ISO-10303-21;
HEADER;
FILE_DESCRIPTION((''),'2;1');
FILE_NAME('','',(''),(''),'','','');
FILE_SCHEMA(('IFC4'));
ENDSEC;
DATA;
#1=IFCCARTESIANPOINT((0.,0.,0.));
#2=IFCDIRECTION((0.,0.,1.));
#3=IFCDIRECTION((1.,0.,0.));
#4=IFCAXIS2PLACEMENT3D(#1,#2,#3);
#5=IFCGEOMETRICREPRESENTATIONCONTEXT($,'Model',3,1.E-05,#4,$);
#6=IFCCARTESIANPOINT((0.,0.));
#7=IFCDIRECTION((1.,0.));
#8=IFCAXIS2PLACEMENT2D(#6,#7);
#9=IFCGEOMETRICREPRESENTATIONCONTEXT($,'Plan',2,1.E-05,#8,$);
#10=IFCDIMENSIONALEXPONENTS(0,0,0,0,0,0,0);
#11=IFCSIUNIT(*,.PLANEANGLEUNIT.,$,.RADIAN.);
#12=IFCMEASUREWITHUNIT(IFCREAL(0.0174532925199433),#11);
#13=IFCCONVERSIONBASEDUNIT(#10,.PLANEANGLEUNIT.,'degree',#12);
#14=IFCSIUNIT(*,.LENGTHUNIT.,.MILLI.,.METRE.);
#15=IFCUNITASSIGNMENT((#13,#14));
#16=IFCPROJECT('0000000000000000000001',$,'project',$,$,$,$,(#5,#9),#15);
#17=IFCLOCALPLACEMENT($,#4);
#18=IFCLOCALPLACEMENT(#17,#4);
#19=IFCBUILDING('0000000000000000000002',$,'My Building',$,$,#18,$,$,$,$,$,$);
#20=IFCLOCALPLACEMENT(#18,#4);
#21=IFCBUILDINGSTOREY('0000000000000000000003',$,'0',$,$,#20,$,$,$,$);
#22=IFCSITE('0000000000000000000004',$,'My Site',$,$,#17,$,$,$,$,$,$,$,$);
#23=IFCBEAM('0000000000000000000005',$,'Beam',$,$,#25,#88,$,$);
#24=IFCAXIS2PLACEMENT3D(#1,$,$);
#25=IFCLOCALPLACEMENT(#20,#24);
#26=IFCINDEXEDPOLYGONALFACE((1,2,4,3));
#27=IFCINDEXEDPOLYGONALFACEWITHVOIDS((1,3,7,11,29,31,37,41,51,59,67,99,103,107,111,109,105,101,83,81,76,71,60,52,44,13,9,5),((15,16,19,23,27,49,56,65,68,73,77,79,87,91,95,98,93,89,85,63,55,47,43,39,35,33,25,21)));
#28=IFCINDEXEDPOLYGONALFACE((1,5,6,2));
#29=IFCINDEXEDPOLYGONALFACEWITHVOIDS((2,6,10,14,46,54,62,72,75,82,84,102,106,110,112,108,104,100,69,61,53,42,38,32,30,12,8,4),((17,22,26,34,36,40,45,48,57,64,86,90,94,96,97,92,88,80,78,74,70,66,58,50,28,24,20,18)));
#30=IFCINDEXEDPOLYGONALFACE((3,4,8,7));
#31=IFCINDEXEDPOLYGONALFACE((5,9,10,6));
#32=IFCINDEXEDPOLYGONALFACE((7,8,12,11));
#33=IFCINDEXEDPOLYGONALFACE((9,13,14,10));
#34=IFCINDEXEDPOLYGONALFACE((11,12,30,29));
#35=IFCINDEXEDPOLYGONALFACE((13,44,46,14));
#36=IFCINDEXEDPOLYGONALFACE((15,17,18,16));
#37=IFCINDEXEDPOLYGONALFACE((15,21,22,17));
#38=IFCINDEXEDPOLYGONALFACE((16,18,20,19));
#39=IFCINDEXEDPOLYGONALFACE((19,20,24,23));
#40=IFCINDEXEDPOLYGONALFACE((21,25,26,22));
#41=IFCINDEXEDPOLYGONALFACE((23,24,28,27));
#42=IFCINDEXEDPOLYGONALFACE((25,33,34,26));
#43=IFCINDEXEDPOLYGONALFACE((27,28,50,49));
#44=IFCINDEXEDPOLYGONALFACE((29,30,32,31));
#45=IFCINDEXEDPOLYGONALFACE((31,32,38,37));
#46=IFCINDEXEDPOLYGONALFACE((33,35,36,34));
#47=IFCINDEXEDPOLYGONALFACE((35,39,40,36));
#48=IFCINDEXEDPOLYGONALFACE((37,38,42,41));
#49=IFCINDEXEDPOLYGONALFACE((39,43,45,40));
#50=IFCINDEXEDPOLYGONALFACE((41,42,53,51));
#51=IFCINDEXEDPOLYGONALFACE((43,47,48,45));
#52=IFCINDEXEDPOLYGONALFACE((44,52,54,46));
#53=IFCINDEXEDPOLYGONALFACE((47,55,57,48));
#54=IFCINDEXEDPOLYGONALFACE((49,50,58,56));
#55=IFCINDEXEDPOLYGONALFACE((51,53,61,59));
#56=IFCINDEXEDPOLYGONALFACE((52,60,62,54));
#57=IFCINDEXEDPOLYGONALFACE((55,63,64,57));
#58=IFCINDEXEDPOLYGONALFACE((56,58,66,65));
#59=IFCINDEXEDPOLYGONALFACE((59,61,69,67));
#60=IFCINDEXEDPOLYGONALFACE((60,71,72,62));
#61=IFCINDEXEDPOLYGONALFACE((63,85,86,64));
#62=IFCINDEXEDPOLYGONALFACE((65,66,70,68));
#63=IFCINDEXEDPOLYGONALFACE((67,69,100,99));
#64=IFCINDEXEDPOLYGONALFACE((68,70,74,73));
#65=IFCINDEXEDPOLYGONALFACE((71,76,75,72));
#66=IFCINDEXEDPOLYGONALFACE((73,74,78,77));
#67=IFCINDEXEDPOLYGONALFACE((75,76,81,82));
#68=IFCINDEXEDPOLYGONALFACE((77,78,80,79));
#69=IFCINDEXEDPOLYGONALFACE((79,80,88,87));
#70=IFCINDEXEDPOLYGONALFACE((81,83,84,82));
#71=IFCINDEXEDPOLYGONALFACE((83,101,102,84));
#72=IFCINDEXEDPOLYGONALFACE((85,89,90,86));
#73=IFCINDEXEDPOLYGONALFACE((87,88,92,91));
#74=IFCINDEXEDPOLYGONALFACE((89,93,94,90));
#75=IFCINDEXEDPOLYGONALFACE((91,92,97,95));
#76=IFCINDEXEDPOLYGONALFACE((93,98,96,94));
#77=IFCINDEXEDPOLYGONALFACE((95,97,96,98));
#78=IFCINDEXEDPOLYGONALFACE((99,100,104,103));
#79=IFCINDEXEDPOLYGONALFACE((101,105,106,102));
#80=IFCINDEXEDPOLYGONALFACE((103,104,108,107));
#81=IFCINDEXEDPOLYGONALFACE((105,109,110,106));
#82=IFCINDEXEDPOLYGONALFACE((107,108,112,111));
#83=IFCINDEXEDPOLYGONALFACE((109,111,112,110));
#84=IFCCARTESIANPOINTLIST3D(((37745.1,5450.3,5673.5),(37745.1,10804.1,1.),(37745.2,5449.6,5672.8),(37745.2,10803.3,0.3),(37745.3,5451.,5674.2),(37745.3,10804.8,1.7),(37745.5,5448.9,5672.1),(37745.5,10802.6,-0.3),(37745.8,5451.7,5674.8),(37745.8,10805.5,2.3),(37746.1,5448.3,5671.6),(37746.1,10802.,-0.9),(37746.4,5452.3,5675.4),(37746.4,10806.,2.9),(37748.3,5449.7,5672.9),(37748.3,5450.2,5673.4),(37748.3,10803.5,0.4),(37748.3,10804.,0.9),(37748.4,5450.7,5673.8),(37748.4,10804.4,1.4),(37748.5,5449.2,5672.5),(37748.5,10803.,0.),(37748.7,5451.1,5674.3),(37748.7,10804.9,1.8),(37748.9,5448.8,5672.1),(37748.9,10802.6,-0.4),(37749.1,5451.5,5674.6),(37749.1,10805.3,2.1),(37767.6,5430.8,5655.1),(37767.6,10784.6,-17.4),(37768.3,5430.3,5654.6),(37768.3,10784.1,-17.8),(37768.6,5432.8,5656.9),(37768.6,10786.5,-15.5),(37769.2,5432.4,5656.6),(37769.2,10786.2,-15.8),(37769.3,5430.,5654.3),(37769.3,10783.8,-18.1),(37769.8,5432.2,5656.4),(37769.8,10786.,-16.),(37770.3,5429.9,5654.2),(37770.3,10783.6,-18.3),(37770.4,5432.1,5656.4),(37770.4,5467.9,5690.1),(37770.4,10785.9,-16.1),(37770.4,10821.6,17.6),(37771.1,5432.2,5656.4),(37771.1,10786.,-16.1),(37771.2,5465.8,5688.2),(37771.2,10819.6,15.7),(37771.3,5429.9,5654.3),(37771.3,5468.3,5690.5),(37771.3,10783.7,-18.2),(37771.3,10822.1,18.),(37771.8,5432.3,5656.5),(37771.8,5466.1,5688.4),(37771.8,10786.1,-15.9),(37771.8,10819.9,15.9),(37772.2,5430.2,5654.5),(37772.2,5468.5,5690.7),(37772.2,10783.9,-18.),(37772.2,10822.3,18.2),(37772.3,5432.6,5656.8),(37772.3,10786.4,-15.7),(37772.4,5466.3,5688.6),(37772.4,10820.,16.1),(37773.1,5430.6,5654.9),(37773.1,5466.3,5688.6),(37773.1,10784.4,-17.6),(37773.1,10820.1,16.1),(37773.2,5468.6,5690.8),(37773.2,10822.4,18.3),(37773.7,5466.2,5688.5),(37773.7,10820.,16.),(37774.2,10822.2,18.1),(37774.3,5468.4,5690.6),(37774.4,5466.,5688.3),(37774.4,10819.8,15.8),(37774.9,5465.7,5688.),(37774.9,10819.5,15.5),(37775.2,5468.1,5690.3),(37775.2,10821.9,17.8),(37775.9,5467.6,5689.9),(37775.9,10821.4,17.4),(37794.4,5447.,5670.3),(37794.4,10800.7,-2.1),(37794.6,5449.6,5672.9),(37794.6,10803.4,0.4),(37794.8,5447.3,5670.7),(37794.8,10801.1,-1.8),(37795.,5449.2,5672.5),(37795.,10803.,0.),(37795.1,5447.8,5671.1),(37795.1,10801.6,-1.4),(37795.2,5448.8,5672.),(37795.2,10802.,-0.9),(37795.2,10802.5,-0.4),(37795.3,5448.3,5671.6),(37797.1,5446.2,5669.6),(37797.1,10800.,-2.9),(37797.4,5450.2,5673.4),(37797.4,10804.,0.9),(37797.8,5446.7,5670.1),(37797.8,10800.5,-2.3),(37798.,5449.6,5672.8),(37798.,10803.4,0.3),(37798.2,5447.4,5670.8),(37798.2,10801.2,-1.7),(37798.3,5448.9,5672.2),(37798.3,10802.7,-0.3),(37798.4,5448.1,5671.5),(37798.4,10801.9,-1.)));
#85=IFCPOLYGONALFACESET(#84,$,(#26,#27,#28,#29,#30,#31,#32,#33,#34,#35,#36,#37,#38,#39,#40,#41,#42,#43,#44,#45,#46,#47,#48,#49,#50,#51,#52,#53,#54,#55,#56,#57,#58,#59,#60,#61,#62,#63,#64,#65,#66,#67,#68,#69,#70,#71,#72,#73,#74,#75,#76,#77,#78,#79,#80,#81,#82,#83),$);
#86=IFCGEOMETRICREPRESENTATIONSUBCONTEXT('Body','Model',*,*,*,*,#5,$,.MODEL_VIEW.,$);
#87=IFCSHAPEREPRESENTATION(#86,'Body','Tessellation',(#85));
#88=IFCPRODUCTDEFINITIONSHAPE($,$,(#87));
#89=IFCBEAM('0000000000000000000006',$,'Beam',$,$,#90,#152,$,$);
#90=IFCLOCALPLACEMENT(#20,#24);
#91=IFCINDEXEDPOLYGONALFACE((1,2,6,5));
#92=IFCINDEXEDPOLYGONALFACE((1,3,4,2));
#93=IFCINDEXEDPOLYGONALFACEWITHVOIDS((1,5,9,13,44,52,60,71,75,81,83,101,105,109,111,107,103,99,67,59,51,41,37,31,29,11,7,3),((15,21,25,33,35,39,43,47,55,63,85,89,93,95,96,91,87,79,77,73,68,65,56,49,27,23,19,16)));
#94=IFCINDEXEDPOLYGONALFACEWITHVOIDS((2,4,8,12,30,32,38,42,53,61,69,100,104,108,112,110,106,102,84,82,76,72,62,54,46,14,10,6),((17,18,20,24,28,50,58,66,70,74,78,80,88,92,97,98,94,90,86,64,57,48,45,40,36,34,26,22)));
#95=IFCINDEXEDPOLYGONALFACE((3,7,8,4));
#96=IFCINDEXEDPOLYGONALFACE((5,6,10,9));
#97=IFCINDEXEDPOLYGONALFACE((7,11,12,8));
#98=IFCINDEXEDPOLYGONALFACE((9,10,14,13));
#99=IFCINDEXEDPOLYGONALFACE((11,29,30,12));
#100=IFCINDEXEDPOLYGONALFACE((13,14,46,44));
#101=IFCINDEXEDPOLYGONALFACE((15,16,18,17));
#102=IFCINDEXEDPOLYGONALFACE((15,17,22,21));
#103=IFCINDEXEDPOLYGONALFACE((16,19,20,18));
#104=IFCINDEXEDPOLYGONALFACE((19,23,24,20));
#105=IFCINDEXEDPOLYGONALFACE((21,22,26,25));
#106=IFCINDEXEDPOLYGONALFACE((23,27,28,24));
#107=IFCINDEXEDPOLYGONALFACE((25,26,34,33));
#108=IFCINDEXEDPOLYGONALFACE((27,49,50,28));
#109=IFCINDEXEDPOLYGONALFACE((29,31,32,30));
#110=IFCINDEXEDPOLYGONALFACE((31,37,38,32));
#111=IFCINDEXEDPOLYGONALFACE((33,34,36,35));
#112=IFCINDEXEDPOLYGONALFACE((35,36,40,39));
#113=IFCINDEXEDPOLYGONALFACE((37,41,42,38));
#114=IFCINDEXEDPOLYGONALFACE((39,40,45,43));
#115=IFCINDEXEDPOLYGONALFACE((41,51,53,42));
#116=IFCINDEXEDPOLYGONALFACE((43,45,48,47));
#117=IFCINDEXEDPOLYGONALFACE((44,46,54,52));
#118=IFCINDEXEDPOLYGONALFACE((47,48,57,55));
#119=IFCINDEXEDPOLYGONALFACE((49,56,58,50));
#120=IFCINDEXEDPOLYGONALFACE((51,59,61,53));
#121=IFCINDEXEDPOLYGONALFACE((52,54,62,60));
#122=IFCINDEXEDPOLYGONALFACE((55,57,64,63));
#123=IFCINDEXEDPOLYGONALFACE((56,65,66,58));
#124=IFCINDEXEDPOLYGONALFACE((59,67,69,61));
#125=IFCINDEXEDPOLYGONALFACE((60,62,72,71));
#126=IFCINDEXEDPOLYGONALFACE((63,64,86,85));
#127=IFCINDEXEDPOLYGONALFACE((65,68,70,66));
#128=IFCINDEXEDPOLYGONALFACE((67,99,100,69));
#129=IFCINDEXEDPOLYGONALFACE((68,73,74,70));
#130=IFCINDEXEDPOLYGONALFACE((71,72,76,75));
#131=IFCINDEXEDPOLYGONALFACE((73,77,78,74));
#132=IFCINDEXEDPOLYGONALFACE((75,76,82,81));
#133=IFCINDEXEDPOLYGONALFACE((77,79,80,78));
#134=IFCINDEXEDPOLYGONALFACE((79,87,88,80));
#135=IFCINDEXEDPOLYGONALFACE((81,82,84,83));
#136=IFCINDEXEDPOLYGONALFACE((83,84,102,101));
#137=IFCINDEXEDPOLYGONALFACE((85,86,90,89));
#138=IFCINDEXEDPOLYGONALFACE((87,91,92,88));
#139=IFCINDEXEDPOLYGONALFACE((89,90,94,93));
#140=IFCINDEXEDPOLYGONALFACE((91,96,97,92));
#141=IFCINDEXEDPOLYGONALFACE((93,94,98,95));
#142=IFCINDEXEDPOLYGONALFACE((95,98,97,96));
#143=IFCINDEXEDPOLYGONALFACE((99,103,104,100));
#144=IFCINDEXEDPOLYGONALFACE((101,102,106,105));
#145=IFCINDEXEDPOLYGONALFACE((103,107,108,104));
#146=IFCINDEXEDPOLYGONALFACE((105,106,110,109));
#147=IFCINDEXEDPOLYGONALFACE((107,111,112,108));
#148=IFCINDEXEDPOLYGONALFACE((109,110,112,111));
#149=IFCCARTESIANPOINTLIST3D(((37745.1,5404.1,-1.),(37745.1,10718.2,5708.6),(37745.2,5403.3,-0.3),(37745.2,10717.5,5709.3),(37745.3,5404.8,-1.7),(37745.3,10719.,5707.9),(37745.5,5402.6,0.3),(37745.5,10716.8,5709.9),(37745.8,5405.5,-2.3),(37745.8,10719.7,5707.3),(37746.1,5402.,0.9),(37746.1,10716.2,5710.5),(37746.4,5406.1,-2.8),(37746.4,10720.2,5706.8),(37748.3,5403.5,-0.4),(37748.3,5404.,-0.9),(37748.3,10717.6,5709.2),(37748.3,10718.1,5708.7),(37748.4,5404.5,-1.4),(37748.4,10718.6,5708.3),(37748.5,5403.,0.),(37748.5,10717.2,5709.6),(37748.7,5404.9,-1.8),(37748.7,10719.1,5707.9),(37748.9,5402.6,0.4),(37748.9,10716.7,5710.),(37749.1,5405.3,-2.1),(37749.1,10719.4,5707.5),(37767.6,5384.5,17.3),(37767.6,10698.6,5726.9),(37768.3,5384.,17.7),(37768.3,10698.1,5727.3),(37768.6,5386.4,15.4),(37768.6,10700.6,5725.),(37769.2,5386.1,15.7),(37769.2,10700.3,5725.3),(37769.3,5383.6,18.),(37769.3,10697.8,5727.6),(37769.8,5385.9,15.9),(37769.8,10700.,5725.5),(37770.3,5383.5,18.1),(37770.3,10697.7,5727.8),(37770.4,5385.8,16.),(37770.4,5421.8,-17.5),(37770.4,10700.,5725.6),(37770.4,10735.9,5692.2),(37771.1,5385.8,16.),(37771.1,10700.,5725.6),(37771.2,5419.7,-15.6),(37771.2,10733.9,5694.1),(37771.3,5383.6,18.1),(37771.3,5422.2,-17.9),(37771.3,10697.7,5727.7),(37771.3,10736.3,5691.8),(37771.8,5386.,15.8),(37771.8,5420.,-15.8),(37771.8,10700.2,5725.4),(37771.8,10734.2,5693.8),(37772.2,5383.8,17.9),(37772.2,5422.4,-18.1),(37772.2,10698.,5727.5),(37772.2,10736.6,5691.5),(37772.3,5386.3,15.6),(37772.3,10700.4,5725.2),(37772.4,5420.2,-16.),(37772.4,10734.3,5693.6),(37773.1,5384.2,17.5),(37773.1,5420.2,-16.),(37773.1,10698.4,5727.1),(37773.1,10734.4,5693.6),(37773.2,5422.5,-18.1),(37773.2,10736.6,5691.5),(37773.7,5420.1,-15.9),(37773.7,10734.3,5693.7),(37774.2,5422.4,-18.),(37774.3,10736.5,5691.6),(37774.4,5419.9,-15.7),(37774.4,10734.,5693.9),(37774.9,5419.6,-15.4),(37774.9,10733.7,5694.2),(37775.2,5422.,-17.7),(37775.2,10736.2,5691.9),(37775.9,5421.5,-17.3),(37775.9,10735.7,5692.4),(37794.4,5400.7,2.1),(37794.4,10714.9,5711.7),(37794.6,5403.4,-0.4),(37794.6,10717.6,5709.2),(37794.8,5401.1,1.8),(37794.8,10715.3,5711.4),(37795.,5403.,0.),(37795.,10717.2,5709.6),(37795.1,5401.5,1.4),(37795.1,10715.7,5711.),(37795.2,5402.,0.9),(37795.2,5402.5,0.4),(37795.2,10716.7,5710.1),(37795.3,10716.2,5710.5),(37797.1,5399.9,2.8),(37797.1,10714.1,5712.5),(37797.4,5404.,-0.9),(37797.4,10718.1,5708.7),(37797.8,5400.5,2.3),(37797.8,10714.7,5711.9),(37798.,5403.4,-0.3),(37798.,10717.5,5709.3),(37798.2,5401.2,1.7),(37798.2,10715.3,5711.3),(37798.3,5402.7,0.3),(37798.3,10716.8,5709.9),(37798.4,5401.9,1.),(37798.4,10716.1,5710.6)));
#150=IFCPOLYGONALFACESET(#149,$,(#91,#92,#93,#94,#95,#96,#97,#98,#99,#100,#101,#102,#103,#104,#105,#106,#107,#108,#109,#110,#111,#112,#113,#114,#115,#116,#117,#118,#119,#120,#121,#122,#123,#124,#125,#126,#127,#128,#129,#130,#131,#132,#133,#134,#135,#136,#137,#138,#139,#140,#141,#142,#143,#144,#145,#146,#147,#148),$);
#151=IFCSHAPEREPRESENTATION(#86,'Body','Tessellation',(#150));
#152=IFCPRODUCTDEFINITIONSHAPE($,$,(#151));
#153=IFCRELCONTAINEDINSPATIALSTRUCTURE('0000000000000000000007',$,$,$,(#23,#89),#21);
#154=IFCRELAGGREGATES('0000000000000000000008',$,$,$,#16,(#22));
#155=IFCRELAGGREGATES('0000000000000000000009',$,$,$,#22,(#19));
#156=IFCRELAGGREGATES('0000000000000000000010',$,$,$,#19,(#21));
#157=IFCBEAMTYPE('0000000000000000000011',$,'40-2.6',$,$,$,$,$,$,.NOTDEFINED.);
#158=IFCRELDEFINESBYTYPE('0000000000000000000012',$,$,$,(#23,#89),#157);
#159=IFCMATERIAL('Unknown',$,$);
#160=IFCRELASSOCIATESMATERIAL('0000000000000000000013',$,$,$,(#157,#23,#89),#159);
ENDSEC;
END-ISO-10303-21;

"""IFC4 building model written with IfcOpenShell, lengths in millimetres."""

from ifc_helpers import new_model, entity, si_unit, converted_unit, frame, origin_with_axes, origin_2d_with_axis, place, context, subcontext, project, spatial, hollow_rectangle, extrude, material, material_profile, profile_set, profile_usage, type_object, element, save


model = new_model("IFC4")

# Units and contexts
model_context = context("Model", 3, precision=1e-05, world=origin_with_axes())
plan_context = context("Plan", 2, precision=1e-05, world=origin_2d_with_axis())
body_context = subcontext(model_context, "Body", "Model", "MODEL_VIEW")
ifc_project = project(units=[converted_unit("PLANEANGLEUNIT", "degree", entity("IfcReal", 0.0174532925199433), si_unit("PLANEANGLEUNIT", "RADIAN"), dimensions=[0, 0, 0, 0, 0, 0, 0]), si_unit("LENGTHUNIT", "METRE", prefix="MILLI")], contexts=[model_context, plan_context])

# Site, building, storey
site_placement = place(None, origin_with_axes())
site = spatial("IfcSite", under=ifc_project, at=site_placement, Name="My Site")
building_placement = place(site_placement, origin_with_axes())
building = spatial("IfcBuilding", under=site, at=building_placement, Name="My Building")
storey_placement = place(building_placement, origin_with_axes())
storey = spatial("IfcBuildingStorey", under=building, at=storey_placement, Name="0")

# Shared definitions
ifc_material = material(Name="Unknown")

# Beams
ifc_material_profile_1 = material_profile(ifc_material, hollow_rectangle(XDim=40.0, YDim=40.0, WallThickness=2.6, InnerFilletRadius=2.6, OuterFilletRadius=3.9))
ifc_profile_set_1 = profile_set([ifc_material_profile_1])
beam_type = type_object("IfcBeamType", Name="40-2.6", PredefinedType="NOTDEFINED", material=ifc_profile_set_1)
ifc_profile_usage_1 = profile_usage(ifc_profile_set_1, cardinal=5)
beam_1_placement = place(storey_placement, frame((37771.8, 10803.0, 0.0), z_axis=(0.0, -0.686382, 0.727241), x_axis=(-0.666409, 0.542221, 0.511757)))
element("IfcBeam", 1, at=beam_1_placement, inside=storey, type_object=beam_type, material=ifc_profile_usage_1, Name="Beam", context=body_context, shape_type="SweptSolid", body=[
    extrude(hollow_rectangle(XDim=40.0, YDim=40.0, WallThickness=2.6, InnerFilletRadius=2.6, OuterFilletRadius=3.9), origin_with_axes(), (0.0, 0.0, 1.0), 7800.0),
])
ifc_profile_usage_2 = profile_usage(ifc_profile_set_1, cardinal=5)
beam_2_placement = place(storey_placement, frame((37771.8, 5403.0, 0.0), z_axis=(0.0, 0.681302, 0.732003), x_axis=(-0.666409, 0.545771, -0.507969)))
element("IfcBeam", 2, at=beam_2_placement, inside=storey, type_object=beam_type, material=ifc_profile_usage_2, Name="Beam", context=body_context, shape_type="SweptSolid", body=[
    extrude(hollow_rectangle(XDim=40.0, YDim=40.0, WallThickness=2.6, InnerFilletRadius=2.6, OuterFilletRadius=3.9), origin_with_axes(), (0.0, 0.0, 1.0), 7800.0),
])

save(model, "model.ifc")
